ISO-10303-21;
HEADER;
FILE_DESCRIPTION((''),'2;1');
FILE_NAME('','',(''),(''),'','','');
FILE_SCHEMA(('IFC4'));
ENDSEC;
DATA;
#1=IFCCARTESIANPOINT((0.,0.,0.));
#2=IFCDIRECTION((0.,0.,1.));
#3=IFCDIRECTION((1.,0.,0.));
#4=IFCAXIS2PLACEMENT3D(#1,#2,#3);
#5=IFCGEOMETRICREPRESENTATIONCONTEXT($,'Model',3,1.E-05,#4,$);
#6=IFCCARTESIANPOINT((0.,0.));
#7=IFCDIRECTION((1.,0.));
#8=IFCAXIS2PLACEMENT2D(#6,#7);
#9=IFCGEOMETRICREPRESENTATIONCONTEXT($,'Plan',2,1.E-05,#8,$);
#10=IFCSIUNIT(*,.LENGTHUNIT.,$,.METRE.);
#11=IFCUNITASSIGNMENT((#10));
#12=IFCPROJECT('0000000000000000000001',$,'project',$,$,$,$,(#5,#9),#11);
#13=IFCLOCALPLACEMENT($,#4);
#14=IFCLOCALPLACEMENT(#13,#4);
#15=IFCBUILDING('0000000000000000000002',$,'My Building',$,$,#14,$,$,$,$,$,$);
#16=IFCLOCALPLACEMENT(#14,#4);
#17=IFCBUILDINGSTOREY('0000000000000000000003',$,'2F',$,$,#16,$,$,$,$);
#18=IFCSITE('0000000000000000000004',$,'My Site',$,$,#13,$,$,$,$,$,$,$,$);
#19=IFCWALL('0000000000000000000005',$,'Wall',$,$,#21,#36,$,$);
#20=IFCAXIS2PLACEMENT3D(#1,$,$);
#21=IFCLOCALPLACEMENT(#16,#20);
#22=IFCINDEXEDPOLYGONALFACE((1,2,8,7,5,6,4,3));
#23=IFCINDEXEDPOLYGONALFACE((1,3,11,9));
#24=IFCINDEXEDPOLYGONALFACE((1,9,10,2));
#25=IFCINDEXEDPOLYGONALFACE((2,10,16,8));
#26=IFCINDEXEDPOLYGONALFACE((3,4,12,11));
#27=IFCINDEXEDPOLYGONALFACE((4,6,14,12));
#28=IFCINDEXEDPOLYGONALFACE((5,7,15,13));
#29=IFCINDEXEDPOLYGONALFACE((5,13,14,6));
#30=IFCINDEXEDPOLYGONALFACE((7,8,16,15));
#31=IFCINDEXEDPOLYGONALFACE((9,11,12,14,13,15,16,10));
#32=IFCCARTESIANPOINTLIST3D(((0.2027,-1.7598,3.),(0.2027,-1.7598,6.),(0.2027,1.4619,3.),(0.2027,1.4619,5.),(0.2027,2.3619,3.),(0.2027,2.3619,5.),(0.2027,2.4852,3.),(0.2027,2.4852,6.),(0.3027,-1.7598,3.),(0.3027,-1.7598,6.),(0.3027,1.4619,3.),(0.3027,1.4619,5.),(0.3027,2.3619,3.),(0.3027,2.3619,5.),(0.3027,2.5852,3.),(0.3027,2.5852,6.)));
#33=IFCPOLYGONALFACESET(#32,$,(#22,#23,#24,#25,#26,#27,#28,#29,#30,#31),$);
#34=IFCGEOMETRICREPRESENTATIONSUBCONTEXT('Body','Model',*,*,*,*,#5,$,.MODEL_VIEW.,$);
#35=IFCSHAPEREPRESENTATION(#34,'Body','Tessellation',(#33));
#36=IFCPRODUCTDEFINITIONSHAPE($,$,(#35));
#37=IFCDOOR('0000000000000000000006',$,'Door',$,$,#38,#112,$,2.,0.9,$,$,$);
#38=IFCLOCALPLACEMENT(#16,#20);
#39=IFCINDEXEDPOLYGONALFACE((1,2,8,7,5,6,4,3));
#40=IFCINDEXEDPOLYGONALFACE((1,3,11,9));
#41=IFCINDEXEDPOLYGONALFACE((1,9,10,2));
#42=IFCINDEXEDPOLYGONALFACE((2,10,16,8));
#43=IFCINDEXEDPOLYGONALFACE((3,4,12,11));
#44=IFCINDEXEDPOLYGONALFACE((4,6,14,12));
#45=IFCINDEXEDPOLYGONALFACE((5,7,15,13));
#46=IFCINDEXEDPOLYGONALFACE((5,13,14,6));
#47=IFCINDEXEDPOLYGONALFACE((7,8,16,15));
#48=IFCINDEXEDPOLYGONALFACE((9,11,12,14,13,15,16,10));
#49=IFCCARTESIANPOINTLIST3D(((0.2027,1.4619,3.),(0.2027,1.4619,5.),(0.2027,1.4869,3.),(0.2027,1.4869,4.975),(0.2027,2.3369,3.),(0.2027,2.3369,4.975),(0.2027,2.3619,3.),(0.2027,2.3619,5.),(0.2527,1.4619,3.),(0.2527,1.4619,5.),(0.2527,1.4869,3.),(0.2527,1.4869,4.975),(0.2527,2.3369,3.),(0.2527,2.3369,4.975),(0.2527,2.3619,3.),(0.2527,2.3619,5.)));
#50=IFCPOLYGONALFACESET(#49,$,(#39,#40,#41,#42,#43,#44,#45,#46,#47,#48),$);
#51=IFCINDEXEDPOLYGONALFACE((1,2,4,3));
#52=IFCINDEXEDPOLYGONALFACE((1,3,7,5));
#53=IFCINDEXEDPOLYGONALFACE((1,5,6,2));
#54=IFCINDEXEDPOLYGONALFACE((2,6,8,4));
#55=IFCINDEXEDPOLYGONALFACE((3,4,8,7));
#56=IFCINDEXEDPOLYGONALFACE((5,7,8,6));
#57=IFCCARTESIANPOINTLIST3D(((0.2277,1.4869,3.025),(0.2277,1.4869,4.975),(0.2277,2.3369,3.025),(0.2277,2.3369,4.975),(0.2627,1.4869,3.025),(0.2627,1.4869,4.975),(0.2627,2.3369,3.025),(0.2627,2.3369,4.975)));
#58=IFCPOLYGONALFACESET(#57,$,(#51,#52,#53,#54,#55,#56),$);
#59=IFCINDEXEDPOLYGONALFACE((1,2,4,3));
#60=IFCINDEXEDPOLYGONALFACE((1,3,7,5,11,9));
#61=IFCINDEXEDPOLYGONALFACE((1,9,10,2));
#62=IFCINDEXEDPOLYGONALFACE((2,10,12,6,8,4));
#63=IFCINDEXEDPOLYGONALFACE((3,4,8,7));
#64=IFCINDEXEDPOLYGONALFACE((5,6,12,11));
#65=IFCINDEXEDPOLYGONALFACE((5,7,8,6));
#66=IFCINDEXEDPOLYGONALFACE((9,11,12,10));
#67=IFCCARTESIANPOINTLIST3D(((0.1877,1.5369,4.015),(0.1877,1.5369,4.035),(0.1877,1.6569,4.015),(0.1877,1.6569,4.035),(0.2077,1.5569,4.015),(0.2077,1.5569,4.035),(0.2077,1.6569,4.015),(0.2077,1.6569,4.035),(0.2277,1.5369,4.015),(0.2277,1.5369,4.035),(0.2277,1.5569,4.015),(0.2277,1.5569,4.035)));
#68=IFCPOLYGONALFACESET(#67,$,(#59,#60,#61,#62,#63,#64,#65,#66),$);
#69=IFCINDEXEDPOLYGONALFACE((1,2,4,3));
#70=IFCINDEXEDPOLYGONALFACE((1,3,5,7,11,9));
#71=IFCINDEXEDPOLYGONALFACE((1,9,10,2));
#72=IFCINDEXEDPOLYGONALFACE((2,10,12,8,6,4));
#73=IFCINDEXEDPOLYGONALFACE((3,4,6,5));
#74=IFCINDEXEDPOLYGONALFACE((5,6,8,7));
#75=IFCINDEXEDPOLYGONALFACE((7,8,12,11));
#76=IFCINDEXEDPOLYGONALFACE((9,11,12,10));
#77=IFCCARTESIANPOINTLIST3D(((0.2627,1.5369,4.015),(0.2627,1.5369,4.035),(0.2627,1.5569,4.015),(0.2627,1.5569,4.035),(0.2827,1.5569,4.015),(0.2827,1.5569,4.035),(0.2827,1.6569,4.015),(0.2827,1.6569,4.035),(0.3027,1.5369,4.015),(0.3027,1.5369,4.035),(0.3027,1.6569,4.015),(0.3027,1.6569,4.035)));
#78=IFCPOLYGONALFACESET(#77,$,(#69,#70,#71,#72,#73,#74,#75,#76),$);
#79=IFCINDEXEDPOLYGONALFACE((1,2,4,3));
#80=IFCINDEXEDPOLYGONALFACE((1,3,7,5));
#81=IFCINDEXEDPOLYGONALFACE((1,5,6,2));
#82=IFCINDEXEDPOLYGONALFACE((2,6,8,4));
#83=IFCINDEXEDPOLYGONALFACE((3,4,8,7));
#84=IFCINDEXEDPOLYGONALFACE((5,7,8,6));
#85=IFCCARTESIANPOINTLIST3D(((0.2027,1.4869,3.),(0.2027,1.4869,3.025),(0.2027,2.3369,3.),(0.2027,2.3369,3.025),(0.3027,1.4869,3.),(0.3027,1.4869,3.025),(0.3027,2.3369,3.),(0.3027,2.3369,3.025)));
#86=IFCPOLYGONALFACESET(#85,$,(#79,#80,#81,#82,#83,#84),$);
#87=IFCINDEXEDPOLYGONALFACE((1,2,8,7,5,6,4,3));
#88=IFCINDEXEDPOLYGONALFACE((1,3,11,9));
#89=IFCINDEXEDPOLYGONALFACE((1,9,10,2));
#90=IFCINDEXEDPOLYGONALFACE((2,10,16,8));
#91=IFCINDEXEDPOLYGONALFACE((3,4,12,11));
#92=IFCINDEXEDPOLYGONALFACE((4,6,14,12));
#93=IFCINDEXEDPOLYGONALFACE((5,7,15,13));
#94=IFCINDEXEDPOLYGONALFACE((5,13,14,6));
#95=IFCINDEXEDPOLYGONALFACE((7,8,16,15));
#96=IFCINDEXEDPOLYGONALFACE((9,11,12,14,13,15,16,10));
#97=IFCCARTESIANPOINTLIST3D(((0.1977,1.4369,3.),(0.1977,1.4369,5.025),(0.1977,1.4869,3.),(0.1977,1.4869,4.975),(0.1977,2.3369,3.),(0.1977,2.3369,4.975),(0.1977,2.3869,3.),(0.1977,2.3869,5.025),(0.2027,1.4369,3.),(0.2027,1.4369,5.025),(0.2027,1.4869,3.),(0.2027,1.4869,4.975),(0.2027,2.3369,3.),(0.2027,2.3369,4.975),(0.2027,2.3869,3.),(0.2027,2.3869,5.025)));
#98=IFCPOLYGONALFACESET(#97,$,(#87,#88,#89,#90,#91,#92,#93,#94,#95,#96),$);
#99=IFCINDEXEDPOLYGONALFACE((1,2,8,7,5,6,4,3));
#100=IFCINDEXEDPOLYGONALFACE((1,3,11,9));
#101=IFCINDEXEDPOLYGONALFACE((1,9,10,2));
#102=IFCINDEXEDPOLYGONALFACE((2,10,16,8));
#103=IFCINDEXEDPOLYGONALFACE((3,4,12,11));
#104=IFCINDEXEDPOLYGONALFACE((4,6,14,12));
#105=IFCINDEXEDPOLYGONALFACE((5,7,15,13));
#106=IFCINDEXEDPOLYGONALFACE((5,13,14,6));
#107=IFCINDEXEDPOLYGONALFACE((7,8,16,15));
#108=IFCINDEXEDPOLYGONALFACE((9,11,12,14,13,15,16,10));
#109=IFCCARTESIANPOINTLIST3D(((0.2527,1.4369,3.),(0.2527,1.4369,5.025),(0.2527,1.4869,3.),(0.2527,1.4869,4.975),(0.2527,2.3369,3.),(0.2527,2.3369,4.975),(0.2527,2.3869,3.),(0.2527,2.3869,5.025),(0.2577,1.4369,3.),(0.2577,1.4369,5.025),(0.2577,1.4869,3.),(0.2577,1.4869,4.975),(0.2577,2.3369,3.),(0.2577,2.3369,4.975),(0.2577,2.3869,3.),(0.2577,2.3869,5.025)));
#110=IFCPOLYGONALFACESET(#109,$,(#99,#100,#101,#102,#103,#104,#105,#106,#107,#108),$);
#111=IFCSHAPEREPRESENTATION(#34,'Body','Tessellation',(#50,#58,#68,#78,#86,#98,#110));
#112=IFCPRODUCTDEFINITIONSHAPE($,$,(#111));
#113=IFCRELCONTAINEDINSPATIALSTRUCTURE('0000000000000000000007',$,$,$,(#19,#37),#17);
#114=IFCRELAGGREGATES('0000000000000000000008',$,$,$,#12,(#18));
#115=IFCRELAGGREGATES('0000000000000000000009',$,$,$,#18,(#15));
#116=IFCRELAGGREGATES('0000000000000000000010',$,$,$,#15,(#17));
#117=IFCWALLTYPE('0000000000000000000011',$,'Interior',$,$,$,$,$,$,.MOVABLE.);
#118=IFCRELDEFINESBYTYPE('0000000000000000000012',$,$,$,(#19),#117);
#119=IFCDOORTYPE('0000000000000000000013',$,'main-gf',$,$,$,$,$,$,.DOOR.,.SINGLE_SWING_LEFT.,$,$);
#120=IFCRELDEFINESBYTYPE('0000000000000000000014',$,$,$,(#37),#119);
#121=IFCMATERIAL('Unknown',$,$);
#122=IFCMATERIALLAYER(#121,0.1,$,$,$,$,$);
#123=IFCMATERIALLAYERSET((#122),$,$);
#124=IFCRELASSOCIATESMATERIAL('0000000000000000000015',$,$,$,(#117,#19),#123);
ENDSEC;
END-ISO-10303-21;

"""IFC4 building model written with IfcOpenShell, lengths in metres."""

from ifc_helpers import new_model, entity, si_unit, frame, origin_with_axes, origin_2d_with_axis, place, context, subcontext, project, spatial, line, indexed_curve, outline, extrude, shape, source, transform, mapped, material, layer, layer_set, layer_usage, type_object, type_shapes, element, fill, save


model = new_model("IFC4")

# Units and contexts
model_context = context("Model", 3, precision=1e-05, world=origin_with_axes())
plan_context = context("Plan", 2, precision=1e-05, world=origin_2d_with_axis())
body_context_1 = subcontext(model_context, "Body", "Model", "MODEL_VIEW")
body_context_2 = subcontext(plan_context, "Body", "Plan", "PLAN_VIEW")
ifc_project = project(units=[si_unit("LENGTHUNIT", "METRE")], contexts=[model_context, plan_context])

# Site, building, storey
site_placement = place(None, origin_with_axes())
site = spatial("IfcSite", under=ifc_project, at=site_placement, Name="My Site")
building_placement = place(site_placement, origin_with_axes())
building = spatial("IfcBuilding", under=site, at=building_placement, Name="My Building")
storey_placement = place(building_placement, origin_with_axes())
storey = spatial("IfcBuildingStorey", under=building, at=storey_placement, Name="2F")

# Shared definitions
ifc_material = material(Name="Unknown")

# Shared definitions
ifc_layer_1 = layer(ifc_material, 0.1)
ifc_layer_set_1 = layer_set([ifc_layer_1])
wall_type = type_object("IfcWallType", Name="Interior", PredefinedType="MOVABLE", material=ifc_layer_set_1)

# Shared definitions
shared_shape_1 = source(origin_with_axes(), body_context_1, "Body", "SweptSolid", [
    extrude(outline(indexed_curve([(0.0, 0.0), (0.9, 0.0), (0.9, 2.0), (0.0, 2.0)], segments=[line(1, 2, 3, 4, 1)])), frame((0.0, -0.6, 0.0), z_axis=(0.0, -1.0, 0.0), x_axis=(1.0, 0.0, 0.0)), (0.0, 0.0, -1.0), 1.2),
])
door_type = type_object("IfcDoorType", Name="main-gf", OperationType="SINGLE_SWING_LEFT", PredefinedType="DOOR")
shared_shape_2 = source(origin_with_axes(), body_context_1, "Body", "SweptSolid", [
    extrude(outline(indexed_curve([(0.0, 0.0), (0.0, 2.0), (0.9, 2.0), (0.9, 0.0), (0.875, 0.0), (0.875, 1.975), (0.025, 1.975), (0.025, 0.0)], segments=[line(1, 2, 3, 4, 5, 6, 7, 8, 1)])), frame((0.0, 0.0, 0.0), z_axis=(0.0, -1.0, 0.0), x_axis=(1.0, 0.0, 0.0)), (0.0, 0.0, -1.0), 0.05),
    extrude(outline(indexed_curve([(0.0, 0.0), (0.85, 0.0), (0.85, 0.035), (0.0, 0.035)], segments=[line(1, 2, 3, 4, 1)])), frame((0.025, 0.025, 0.025), z_axis=(0.0, 0.0, 1.0), x_axis=(1.0, 0.0, 0.0)), (0.0, 0.0, 1.0), 1.95),
    extrude(outline(indexed_curve([(0.0, 0.0), (0.0, -0.04), (-0.12, -0.04), (-0.12, -0.02), (-0.02, -0.02), (-0.02, 0.0)], segments=[line(1, 2, 3, 4, 5, 6, 1)])), frame((0.825, 0.025, 1.015), z_axis=(0.0, 0.0, 1.0), x_axis=(1.0, 0.0, 0.0)), (0.0, 0.0, 1.0), 0.02),
    extrude(outline(indexed_curve([(0.0, 0.0), (0.0, 0.04), (-0.12, 0.04), (-0.12, 0.02), (-0.02, 0.02), (-0.02, 0.0)], segments=[line(1, 2, 3, 4, 5, 6, 1)])), frame((0.825, 0.06, 1.015), z_axis=(0.0, 0.0, 1.0), x_axis=(1.0, 0.0, 0.0)), (0.0, 0.0, 1.0), 0.02),
    extrude(outline(indexed_curve([(0.0, 0.0), (0.85, 0.0), (0.85, 0.1), (0.0, 0.1)], segments=[line(1, 2, 3, 4, 1)])), frame((0.025, 0.0, 0.0), z_axis=(0.0, 0.0, 1.0), x_axis=(1.0, 0.0, 0.0)), (0.0, 0.0, 1.0), 0.025),
    extrude(outline(indexed_curve([(0.0, 0.0), (0.0, 2.025), (0.95, 2.025), (0.95, 0.0), (0.9, 0.0), (0.9, 1.975), (0.05, 1.975), (0.05, 0.0)], segments=[line(1, 2, 3, 4, 5, 6, 7, 8, 1)])), frame((-0.025, -0.005, 0.0), z_axis=(0.0, -1.0, 0.0), x_axis=(1.0, 0.0, 0.0)), (0.0, 0.0, -1.0), 0.005),
    extrude(outline(indexed_curve([(0.0, 0.0), (0.0, 2.025), (0.95, 2.025), (0.95, 0.0), (0.9, 0.0), (0.9, 1.975), (0.05, 1.975), (0.05, 0.0)], segments=[line(1, 2, 3, 4, 5, 6, 7, 8, 1)])), frame((-0.025, 0.05, 0.0), z_axis=(0.0, -1.0, 0.0), x_axis=(1.0, 0.0, 0.0)), (0.0, 0.0, -1.0), 0.005),
])
shared_shape_3 = source(origin_with_axes(), body_context_2, "Body", "Curve2D", [
    entity("IfcIndexedPolyCurve", entity("IfcCartesianPointList2D", [[0.0, 0.0], [0.025, 0.0], [0.025, 0.05], [0.0, 0.05]]), [entity("IfcLineIndex", [1, 2, 3, 4, 1])]),
    entity("IfcIndexedPolyCurve", entity("IfcCartesianPointList2D", [[0.9, 0.0], [0.875, 0.0], [0.875, 0.05], [0.9, 0.05]]), [entity("IfcLineIndex", [1, 2, 3, 4, 1])]),
    entity("IfcIndexedPolyCurve", entity("IfcCartesianPointList2D", [[0.025, 0.05], [0.025, -0.8], [0.06, -0.8]])),
    entity("IfcTrimmedCurve", entity("IfcEllipse", entity("IfcAxis2Placement2D", entity("IfcCartesianPoint", [0.06, 0.05]), entity("IfcDirection", [1.0, 0.0])), 0.815, 0.85), [entity("IfcCartesianPoint", [0.06, -0.8])], [entity("IfcCartesianPoint", [0.06, 0.9])], True, "CARTESIAN"),
    entity("IfcIndexedPolyCurve", entity("IfcCartesianPointList2D", [[0.025, 0.05], [0.06, 0.05], [0.06, 0.9], [0.025, 0.9]]), [entity("IfcLineIndex", [1, 2, 3, 4, 1])]),
])
type_shapes(door_type, [shared_shape_2, shared_shape_3])

# Wall, opening, door
ifc_layer_usage_1 = layer_usage(ifc_layer_set_1, "AXIS2", "POSITIVE", 0.0)
wall_1_placement = place(storey_placement, frame((0.3027, -1.7598, 3.0), z_axis=(0.0, 0.0, 1.0), x_axis=(0.0, 1.0, 0.0)))
wall_1 = element("IfcWall", 1, at=wall_1_placement, inside=storey, type_object=wall_type, material=ifc_layer_usage_1, Name="Wall", context=body_context_1, shape_type="SweptSolid", body=[
    extrude(outline(indexed_curve([(0.0, 0.0), (0.0, 0.1), (4.245, 0.1), (4.345, 0.0)], segments=[line(1, 2, 3, 4, 1)])), origin_with_axes(), (0.0, 0.0, 1.0), 3.0),
])
opening_1_placement = place(wall_1_placement, frame((4.1217, 0.1, 0.0), z_axis=(0.0, 0.0, 1.0), x_axis=(-1.0, 0.0, 0.0)))
opening_1 = element("IfcOpeningElement", 2, at=opening_1_placement, cuts=wall_1, PredefinedType="OPENING", context=body_context_1, shape_type="MappedRepresentation", body=[
    mapped(shared_shape_1, transform((0.0, 0.0, 0.0), x_axis=(1.0, 0.0, 0.0), y_axis=(0.0, 1.0, 0.0), z_axis=(0.0, 0.0, 1.0), scale=1.0)),
])
door_1_placement = place(opening_1_placement, origin_with_axes())
door_1 = element("IfcDoor", 3, at=door_1_placement, inside=storey, type_object=door_type, Name="Door", OverallHeight=2.0, OverallWidth=0.9, shapes=[
    shape(body_context_1, "Body", "MappedRepresentation", [mapped(shared_shape_2, transform((0.0, 0.0, 0.0), x_axis=(1.0, 0.0, 0.0), y_axis=(0.0, 1.0, 0.0), z_axis=(0.0, 0.0, 1.0), scale=1.0))]),
    shape(body_context_2, "Body", "MappedRepresentation", [mapped(shared_shape_3, transform((0.0, 0.0, 0.0), x_axis=(1.0, 0.0, 0.0), y_axis=(0.0, 1.0, 0.0), z_axis=(0.0, 0.0, 1.0), scale=1.0))]),
])
fill(opening_1, door_1)

save(model, "model.ifc")
